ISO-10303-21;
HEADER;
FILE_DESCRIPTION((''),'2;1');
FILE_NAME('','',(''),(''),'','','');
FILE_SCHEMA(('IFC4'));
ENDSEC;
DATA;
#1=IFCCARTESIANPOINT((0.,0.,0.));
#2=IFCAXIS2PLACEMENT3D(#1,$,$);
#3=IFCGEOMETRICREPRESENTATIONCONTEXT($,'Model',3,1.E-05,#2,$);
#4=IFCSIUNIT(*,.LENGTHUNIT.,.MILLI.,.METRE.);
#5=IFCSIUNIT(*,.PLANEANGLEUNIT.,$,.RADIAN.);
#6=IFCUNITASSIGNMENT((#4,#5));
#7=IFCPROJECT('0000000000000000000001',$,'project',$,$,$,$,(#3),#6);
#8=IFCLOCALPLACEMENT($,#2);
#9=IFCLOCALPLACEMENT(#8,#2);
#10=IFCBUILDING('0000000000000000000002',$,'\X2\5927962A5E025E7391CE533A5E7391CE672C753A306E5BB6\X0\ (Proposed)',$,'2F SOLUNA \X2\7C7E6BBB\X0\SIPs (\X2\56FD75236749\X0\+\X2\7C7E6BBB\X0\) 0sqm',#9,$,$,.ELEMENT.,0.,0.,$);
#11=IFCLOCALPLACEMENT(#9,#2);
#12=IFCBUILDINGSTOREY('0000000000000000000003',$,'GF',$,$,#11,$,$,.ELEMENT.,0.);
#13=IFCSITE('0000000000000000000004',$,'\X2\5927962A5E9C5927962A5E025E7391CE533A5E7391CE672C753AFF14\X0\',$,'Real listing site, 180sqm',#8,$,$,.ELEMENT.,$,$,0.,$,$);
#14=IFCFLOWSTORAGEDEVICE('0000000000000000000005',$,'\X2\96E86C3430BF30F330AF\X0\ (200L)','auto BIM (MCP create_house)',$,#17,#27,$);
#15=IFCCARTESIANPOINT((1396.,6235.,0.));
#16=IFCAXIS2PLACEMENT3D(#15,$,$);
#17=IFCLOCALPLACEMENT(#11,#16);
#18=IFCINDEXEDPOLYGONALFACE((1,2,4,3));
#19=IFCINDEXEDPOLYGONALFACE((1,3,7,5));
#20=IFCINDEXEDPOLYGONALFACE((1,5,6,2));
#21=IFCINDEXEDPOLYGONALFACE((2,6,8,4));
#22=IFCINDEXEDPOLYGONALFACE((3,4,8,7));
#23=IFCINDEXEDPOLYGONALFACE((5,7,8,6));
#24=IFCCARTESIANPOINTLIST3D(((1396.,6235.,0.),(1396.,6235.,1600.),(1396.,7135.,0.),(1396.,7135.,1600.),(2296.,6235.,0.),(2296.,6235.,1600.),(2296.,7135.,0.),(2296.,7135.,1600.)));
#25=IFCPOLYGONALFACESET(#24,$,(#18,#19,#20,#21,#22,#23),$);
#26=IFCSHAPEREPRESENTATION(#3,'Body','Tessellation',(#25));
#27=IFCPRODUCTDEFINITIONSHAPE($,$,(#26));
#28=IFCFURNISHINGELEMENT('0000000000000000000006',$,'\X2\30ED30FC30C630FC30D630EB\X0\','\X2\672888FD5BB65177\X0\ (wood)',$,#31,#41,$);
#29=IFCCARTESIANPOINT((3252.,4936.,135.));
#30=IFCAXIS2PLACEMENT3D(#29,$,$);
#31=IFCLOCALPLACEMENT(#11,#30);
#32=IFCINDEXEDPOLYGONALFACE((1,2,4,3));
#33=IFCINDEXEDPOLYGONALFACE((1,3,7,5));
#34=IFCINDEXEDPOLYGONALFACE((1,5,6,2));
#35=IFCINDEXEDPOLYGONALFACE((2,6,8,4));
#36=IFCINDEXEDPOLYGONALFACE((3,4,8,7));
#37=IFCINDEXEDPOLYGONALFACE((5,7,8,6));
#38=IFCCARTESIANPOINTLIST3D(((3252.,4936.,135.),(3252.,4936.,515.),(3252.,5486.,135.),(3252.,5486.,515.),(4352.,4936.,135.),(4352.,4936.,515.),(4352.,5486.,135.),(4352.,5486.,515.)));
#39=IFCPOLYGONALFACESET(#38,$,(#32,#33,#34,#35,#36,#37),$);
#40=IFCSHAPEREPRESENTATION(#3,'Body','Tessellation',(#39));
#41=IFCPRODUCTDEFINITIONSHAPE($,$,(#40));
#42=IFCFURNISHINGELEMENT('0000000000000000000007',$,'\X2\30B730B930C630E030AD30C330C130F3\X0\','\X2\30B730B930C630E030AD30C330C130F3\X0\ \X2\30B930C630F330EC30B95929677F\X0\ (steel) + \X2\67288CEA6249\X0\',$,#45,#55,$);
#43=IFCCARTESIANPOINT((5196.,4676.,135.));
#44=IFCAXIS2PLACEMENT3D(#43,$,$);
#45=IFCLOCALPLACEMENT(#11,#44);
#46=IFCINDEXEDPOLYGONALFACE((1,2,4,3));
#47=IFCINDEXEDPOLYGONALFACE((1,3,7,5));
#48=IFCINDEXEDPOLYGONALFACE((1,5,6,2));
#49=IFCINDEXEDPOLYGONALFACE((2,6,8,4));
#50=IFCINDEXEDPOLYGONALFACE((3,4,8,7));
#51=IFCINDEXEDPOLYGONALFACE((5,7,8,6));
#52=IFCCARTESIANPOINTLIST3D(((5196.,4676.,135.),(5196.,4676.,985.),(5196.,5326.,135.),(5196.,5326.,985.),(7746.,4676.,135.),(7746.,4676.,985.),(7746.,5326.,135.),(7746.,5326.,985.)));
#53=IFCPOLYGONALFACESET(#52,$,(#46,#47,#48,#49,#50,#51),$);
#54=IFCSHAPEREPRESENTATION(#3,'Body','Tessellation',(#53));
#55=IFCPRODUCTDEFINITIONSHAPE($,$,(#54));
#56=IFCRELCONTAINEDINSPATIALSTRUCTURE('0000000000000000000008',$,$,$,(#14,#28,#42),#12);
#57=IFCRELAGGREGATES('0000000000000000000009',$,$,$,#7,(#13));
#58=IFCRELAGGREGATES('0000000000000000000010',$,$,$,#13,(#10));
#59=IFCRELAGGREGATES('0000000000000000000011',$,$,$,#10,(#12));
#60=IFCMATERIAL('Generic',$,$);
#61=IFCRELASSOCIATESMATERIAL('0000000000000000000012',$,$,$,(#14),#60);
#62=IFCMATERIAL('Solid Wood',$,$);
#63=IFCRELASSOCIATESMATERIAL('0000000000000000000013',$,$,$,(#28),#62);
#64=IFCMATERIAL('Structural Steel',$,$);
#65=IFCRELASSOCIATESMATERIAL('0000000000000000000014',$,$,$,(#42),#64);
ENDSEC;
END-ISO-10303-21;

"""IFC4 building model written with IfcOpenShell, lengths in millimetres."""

from ifc_helpers import new_model, si_unit, frame, frame_2d, origin, place, context, project, spatial, rectangle, extrude, material, element, save


model = new_model("IFC4")

# Units and contexts
model_context = context("Model", 3, precision=1e-05, world=origin())
ifc_project = project(units=[si_unit("LENGTHUNIT", "METRE", prefix="MILLI"), si_unit("PLANEANGLEUNIT", "RADIAN")], contexts=[model_context])

# Site, building, storey
site_placement = place(None, origin())
site = spatial("IfcSite", under=ifc_project, at=site_placement, Name="大阪府大阪市平野区平野本町４", ObjectType="Real listing site, 180sqm", CompositionType="ELEMENT", RefElevation=0.0)
building_placement = place(site_placement, origin())
building = spatial("IfcBuilding", under=site, at=building_placement, Name="大阪市平野区平野本町の家 (Proposed)", ObjectType="2F SOLUNA 籾殻SIPs (国産杉+籾殻) 0sqm", CompositionType="ELEMENT", ElevationOfRefHeight=0.0, ElevationOfTerrain=0.0)
storey_placement = place(building_placement, origin())
storey = spatial("IfcBuildingStorey", under=building, at=storey_placement, Name="GF", CompositionType="ELEMENT", Elevation=0.0)

# Shared definitions
ifc_material_1 = material(Name="Solid Wood")

# Shared definitions
ifc_material_2 = material(Name="Generic")

# Flow storage device
flow_storage_device_placement = place(storey_placement, frame((1396.0, 6235.0, 0.0)))
element("IfcFlowStorageDevice", 1, at=flow_storage_device_placement, inside=storey, material=ifc_material_2, Name="雨水タンク (200L)", Description="auto BIM (MCP create_house)", context=model_context, shape_type="SweptSolid", body=[
    extrude(rectangle(XDim=900.0, YDim=900.0, at=frame_2d((450.0, 450.0))), frame((1396.0, 6235.0, 0.0)), (0.0, 0.0, 1.0), 1600.0),
])

# Furnishing elements
furnishing_1_placement = place(storey_placement, frame((3252.0, 4936.0, 135.0)))
element("IfcFurnishingElement", 2, at=furnishing_1_placement, inside=storey, material=ifc_material_1, Name="ローテーブル", Description="木製家具 (wood)", context=model_context, shape_type="SweptSolid", body=[
    extrude(rectangle(XDim=1100.0, YDim=550.0, at=frame_2d((550.0, 275.0))), frame((3252.0, 4936.0, 135.0)), (0.0, 0.0, 1.0), 380.0),
])
ifc_material_3 = material(Name="Structural Steel")
furnishing_2_placement = place(storey_placement, frame((5196.0, 4676.0, 135.0)))
element("IfcFurnishingElement", 3, at=furnishing_2_placement, inside=storey, material=ifc_material_3, Name="システムキッチン", Description="システムキッチン ステンレス天板 (steel) + 木質扉", context=model_context, shape_type="SweptSolid", body=[
    extrude(rectangle(XDim=2550.0, YDim=650.0, at=frame_2d((1275.0, 325.0))), frame((5196.0, 4676.0, 135.0)), (0.0, 0.0, 1.0), 850.0),
])

save(model, "model.ifc")
